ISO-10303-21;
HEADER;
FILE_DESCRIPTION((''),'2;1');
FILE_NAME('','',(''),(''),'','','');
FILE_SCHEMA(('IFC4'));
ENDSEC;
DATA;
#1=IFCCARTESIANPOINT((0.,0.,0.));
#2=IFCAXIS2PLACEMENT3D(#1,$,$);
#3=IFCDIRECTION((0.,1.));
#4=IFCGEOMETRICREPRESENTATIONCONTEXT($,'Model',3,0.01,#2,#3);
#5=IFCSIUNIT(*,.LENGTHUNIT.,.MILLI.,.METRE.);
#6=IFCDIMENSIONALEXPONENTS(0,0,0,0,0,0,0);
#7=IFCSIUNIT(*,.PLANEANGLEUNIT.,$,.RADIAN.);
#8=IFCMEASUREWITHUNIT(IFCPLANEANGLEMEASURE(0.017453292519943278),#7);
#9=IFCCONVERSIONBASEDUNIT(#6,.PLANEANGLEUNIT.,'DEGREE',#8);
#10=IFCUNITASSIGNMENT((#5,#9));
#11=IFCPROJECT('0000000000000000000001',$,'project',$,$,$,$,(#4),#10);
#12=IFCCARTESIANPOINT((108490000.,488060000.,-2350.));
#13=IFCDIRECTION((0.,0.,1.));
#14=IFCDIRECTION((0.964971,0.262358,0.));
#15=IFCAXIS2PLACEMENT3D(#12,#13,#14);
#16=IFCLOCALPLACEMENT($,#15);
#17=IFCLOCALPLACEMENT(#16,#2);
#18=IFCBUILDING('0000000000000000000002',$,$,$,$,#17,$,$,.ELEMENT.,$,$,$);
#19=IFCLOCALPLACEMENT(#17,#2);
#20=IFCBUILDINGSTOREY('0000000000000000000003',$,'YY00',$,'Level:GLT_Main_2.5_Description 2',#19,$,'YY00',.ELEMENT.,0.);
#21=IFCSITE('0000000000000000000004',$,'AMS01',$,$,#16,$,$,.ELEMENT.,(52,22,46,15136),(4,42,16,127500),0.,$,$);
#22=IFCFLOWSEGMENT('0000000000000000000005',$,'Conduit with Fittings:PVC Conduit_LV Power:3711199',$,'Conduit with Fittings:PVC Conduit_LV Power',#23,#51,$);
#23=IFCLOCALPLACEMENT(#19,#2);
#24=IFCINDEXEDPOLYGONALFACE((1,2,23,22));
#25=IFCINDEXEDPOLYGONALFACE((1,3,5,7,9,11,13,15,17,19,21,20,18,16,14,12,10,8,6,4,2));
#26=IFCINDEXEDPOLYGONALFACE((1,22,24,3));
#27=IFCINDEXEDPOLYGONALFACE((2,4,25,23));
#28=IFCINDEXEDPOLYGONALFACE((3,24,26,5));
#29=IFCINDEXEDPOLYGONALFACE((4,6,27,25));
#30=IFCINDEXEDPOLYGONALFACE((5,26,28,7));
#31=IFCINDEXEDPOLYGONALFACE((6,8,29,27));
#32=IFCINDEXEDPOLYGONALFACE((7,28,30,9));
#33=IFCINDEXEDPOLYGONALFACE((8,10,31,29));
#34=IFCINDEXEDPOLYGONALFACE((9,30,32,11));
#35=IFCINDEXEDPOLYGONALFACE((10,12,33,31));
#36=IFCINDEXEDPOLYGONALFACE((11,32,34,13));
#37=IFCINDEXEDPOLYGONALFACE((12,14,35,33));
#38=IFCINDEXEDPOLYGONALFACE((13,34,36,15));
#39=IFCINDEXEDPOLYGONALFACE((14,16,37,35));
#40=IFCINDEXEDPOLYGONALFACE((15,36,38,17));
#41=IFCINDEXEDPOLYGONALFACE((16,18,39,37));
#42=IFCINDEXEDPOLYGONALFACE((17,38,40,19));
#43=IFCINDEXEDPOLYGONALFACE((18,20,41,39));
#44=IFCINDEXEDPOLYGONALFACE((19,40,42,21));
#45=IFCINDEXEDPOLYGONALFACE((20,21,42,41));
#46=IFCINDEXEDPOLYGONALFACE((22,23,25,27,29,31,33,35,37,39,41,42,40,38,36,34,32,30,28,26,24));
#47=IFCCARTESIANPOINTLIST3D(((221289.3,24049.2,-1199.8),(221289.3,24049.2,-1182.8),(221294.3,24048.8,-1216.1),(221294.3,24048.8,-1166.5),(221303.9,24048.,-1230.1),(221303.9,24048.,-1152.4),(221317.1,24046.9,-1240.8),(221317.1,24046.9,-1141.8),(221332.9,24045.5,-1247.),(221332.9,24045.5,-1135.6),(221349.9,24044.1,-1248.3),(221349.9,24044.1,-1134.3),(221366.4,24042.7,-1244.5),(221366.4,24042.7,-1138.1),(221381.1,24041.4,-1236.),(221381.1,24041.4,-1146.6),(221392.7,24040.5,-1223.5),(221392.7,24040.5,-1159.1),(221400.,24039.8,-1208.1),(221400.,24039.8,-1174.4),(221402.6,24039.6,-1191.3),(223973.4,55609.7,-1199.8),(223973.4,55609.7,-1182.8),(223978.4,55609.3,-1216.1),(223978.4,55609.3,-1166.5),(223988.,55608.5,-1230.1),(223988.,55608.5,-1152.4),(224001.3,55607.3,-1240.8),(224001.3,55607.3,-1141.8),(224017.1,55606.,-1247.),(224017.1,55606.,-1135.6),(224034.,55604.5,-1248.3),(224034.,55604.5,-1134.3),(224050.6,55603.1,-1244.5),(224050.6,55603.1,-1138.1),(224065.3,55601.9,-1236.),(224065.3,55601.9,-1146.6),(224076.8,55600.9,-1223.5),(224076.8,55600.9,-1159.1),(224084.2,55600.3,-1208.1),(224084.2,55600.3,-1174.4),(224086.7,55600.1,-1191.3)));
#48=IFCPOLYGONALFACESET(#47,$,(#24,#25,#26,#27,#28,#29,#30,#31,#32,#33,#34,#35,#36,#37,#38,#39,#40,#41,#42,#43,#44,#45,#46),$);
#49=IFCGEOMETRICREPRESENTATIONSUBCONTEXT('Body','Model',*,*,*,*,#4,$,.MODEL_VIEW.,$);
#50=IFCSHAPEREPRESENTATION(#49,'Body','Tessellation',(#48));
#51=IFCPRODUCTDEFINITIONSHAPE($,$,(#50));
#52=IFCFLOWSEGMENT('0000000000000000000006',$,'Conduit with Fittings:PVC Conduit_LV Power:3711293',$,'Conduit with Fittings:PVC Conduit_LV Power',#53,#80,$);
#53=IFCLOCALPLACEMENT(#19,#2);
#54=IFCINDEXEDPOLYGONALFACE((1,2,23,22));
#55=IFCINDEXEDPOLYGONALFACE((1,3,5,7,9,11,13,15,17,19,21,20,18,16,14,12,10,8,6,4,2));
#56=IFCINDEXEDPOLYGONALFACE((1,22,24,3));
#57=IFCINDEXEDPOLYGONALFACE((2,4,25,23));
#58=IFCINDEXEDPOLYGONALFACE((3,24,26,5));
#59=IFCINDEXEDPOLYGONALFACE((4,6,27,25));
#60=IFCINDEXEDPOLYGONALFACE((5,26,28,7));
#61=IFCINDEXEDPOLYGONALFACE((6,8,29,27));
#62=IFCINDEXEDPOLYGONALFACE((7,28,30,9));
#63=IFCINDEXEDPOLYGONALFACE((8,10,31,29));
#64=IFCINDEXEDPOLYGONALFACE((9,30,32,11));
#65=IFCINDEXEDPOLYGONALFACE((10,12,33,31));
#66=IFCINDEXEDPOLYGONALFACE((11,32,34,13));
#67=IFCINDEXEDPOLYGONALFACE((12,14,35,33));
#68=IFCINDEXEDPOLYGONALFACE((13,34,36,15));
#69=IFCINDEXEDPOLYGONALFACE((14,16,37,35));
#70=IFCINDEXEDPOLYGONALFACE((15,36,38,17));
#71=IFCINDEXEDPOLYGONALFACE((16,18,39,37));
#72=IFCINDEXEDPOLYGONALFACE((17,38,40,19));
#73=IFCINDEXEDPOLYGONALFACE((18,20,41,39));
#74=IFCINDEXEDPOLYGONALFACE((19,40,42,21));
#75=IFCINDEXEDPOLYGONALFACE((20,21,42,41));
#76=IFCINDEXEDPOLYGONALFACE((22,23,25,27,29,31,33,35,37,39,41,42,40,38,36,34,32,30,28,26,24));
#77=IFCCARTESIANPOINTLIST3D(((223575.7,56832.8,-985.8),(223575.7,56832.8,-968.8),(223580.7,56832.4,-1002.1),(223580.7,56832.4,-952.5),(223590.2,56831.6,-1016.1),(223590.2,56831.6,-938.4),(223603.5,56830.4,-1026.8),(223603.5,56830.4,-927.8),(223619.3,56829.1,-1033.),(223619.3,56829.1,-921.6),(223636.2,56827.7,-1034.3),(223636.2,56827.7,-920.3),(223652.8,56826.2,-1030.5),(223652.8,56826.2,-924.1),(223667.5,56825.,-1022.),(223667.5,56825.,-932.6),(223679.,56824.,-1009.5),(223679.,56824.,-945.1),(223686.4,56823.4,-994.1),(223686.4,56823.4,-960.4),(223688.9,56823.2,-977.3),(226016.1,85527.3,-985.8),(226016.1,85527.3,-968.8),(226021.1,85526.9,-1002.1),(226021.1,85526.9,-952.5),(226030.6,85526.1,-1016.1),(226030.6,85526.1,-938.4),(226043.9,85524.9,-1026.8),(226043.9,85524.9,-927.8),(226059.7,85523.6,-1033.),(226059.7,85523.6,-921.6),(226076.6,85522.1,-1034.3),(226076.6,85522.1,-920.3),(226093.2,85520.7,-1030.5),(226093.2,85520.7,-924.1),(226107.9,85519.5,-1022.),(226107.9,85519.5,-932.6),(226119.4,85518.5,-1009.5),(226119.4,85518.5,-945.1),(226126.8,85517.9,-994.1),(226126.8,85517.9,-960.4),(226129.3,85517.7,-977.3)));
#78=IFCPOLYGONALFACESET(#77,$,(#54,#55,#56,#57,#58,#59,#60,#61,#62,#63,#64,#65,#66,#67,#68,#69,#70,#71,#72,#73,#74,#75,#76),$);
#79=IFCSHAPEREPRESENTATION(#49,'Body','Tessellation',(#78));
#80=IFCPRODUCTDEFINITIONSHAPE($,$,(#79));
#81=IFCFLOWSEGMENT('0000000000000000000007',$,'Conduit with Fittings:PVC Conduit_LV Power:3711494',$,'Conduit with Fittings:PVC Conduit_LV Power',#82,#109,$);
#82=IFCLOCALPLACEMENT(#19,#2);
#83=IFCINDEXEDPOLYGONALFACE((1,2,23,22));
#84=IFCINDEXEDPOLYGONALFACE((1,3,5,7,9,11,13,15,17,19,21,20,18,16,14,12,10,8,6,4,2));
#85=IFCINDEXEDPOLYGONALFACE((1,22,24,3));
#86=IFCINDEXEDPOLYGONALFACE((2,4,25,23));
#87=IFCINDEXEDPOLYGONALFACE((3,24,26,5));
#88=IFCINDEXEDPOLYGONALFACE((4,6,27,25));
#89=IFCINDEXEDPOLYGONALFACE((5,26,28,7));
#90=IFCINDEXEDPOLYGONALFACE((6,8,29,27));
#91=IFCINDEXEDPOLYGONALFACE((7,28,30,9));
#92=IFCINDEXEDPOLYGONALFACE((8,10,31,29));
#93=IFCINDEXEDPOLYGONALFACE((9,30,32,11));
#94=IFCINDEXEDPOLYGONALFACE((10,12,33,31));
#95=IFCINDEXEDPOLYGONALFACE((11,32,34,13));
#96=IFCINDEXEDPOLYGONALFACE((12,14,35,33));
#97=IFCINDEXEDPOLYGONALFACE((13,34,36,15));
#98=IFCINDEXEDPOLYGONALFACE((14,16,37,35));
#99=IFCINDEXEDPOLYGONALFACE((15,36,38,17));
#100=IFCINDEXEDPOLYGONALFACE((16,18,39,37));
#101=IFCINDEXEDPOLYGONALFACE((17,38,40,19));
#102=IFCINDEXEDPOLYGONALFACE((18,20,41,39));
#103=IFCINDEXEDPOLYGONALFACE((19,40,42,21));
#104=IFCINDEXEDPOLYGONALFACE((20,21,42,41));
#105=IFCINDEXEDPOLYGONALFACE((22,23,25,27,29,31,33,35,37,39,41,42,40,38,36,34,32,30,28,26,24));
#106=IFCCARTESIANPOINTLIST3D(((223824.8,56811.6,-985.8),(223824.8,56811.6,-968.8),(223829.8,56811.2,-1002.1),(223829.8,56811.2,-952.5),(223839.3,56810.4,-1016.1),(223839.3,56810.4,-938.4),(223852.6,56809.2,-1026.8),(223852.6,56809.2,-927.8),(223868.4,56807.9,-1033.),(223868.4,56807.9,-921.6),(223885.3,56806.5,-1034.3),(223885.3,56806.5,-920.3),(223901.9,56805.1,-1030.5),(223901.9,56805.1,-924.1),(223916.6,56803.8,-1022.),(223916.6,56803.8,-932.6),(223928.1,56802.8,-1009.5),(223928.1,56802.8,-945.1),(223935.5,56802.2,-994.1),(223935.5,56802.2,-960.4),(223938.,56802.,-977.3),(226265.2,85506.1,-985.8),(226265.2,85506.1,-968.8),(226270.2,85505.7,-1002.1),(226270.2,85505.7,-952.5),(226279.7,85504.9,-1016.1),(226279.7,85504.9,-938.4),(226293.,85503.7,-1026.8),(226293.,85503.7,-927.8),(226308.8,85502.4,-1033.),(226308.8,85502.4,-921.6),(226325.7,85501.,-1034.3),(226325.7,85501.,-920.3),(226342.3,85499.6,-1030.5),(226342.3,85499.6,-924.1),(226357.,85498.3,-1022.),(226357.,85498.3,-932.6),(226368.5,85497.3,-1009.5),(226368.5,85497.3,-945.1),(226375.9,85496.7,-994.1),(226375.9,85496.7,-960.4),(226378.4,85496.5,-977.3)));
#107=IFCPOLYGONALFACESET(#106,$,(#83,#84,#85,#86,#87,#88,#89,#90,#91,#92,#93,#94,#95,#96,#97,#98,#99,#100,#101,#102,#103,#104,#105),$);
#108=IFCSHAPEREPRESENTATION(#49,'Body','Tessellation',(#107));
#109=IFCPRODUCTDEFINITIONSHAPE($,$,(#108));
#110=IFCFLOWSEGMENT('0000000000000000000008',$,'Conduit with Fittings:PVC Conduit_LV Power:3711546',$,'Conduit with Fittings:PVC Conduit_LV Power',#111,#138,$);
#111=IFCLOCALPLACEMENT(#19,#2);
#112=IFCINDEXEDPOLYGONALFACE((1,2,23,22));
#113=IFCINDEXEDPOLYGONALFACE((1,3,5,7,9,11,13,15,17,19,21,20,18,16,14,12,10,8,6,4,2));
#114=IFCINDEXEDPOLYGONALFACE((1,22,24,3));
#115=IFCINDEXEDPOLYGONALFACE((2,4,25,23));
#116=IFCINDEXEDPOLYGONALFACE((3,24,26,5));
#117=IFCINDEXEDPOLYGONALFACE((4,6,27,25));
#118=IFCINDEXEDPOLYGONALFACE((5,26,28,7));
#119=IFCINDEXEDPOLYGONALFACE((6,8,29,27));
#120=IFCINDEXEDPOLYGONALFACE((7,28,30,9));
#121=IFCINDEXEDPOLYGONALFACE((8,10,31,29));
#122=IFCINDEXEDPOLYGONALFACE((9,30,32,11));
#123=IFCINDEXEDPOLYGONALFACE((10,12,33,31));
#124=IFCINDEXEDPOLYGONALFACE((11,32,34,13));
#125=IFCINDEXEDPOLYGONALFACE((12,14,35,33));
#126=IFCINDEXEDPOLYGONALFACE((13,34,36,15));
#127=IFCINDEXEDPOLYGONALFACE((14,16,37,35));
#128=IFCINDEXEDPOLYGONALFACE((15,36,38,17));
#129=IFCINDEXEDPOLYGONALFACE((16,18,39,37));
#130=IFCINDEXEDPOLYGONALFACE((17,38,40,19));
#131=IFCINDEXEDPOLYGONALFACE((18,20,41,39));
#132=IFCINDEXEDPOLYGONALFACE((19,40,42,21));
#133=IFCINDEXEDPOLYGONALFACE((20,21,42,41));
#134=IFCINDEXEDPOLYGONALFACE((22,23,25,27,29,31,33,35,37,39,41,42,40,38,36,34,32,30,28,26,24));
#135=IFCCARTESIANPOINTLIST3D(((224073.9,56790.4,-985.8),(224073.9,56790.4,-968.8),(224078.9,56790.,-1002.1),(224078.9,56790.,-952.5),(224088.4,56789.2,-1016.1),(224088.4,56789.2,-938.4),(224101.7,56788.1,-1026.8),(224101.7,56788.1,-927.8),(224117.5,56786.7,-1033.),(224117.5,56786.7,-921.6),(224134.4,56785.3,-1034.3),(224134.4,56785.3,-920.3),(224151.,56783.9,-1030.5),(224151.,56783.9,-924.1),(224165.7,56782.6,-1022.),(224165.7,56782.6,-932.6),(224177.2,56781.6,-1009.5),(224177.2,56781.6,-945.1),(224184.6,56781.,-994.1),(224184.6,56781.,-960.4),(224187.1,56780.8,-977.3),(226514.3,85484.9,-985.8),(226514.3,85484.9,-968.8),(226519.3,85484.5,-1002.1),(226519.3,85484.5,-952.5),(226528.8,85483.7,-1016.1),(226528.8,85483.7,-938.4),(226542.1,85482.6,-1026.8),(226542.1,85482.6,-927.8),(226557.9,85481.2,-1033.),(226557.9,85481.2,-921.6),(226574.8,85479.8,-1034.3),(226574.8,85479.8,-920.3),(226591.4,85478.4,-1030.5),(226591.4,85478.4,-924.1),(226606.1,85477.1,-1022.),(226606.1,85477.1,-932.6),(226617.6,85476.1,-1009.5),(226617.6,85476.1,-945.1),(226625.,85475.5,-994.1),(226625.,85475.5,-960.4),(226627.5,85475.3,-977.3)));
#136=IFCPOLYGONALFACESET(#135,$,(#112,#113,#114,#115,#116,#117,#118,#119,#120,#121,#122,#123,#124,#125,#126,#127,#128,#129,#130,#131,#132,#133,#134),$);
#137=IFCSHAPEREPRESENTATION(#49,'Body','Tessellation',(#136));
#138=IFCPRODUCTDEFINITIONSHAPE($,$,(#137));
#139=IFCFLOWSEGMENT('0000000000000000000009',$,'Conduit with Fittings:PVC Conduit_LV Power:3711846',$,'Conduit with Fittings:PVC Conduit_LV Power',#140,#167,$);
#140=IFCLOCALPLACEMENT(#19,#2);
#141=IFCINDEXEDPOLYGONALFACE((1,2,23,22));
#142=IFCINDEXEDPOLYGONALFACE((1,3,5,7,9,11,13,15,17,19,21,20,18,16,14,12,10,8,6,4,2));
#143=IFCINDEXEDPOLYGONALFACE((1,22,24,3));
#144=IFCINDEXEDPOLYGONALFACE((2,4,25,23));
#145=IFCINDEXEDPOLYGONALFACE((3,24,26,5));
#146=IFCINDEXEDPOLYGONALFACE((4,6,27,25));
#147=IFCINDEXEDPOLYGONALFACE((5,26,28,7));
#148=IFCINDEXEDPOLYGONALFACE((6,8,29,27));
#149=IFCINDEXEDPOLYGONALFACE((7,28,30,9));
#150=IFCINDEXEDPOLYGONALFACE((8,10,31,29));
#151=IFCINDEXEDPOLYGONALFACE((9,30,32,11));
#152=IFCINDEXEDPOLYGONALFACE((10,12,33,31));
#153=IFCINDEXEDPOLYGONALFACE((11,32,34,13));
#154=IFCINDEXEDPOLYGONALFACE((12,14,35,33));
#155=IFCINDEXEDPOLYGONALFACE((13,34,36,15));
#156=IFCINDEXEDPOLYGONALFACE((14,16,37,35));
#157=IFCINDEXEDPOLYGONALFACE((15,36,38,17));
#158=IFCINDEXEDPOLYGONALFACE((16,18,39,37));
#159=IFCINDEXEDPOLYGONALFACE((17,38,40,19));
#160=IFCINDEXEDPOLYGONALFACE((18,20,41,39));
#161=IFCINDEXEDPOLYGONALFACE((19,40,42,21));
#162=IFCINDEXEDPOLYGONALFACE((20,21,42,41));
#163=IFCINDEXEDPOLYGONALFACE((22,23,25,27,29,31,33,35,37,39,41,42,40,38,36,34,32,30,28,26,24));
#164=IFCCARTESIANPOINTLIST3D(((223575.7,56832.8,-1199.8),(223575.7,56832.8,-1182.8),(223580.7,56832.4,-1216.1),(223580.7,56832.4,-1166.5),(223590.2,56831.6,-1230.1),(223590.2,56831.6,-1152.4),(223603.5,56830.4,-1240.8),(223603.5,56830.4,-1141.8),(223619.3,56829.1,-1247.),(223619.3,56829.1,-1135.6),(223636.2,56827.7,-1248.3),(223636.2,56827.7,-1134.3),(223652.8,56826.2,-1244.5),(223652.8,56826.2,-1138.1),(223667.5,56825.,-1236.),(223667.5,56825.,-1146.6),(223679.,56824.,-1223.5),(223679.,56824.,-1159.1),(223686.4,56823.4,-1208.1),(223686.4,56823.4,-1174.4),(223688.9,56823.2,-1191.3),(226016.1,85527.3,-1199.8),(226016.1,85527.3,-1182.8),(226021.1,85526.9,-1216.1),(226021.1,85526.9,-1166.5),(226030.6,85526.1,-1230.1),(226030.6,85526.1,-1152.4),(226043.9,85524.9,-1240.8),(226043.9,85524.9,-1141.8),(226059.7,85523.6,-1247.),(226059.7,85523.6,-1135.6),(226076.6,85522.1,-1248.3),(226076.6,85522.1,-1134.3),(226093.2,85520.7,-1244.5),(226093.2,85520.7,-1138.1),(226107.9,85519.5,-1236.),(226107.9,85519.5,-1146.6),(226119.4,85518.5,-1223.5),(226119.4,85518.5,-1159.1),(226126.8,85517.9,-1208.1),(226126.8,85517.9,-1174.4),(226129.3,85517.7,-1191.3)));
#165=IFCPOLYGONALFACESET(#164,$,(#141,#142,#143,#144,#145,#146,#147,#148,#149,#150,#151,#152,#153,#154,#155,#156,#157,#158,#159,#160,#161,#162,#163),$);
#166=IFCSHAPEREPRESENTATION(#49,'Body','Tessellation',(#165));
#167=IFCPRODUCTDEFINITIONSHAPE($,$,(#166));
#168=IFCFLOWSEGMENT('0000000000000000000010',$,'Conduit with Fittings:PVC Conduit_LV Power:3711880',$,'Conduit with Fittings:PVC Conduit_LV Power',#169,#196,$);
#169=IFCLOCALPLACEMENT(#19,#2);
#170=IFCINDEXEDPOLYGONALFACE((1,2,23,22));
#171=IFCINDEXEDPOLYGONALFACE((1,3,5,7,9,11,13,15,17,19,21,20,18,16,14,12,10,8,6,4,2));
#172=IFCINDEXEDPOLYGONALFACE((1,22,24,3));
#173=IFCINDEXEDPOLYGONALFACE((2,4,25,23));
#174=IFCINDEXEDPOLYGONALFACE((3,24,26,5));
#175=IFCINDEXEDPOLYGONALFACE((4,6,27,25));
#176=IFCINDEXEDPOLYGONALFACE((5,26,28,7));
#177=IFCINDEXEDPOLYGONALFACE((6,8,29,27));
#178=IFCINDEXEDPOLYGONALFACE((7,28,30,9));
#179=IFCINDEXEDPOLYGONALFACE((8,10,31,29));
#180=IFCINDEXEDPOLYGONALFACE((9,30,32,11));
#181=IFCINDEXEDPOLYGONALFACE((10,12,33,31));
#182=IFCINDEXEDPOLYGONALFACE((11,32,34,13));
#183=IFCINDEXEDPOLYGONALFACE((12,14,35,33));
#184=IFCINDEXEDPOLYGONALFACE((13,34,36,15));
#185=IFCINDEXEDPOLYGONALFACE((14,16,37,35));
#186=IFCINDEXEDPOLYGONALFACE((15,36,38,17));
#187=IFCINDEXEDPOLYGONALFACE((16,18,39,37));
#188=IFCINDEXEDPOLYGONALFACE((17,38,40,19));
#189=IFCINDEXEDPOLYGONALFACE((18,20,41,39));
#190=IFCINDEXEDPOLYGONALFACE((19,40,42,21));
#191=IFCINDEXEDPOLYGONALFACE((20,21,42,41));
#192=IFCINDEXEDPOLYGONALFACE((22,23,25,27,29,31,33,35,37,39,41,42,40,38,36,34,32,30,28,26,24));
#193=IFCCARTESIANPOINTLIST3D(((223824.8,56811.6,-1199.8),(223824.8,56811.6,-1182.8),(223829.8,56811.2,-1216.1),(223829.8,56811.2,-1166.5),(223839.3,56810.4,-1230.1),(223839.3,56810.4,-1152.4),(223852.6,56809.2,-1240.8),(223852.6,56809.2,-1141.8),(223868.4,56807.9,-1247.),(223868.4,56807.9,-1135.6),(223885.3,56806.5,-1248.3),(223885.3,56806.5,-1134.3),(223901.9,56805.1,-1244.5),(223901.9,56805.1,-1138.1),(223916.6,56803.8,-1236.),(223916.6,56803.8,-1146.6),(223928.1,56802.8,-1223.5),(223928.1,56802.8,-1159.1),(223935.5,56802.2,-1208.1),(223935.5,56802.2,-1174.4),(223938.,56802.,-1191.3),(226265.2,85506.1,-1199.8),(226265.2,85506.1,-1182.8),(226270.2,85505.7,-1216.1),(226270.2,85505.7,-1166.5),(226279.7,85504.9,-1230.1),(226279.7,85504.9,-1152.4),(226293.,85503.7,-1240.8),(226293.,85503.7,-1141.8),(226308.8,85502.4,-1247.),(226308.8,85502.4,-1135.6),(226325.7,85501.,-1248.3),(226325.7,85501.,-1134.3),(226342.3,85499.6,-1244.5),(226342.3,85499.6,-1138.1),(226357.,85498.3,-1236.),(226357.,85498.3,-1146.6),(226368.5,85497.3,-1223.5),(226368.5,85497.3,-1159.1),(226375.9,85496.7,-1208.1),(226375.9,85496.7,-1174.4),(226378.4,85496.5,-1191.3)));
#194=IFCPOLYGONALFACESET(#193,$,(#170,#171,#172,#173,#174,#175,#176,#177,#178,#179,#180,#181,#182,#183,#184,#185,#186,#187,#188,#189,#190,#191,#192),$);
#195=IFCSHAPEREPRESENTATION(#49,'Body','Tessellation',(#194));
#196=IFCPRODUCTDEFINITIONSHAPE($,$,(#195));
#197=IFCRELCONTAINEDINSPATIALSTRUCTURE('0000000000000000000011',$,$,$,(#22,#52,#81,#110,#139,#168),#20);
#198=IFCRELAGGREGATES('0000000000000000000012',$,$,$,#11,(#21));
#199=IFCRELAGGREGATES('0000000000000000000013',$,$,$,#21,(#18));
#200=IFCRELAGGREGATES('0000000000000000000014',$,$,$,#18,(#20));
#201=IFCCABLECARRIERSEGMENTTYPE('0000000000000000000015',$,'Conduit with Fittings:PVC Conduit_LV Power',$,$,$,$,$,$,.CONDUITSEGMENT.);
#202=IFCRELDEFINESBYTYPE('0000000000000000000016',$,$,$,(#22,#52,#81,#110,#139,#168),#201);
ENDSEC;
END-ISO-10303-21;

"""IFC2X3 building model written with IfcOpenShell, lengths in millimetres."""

from ifc_helpers import new_model, entity, si_unit, converted_unit, direction, frame, origin, origin_2d_with_axis, place, context, subcontext, project, spatial, circle, extrude, type_object, element, save


model = new_model("IFC2X3")

# Units and contexts
model_context = context("Model", 3, precision=0.01, world=origin(), true_north=direction((0.0, 1.0)))
body_context = subcontext(model_context, "Body", "Model", "MODEL_VIEW")
ifc_project = project(units=[si_unit("LENGTHUNIT", "METRE", prefix="MILLI"), converted_unit("PLANEANGLEUNIT", "DEGREE", entity("IfcPlaneAngleMeasure", 0.017453292519943278), si_unit("PLANEANGLEUNIT", "RADIAN"), dimensions=[0, 0, 0, 0, 0, 0, 0])], contexts=[model_context])

# Site, building, storey
site_placement = place(None, frame((108490000.0, 488060000.0, -2350.0), z_axis=(0.0, 0.0, 1.0), x_axis=(0.964971, 0.262358, 0.0)))
site = spatial("IfcSite", under=ifc_project, at=site_placement, Name="AMS01", CompositionType="ELEMENT", RefLatitude=(52, 22, 46, 15136), RefLongitude=(4, 42, 16, 127500), RefElevation=0.0)
building_placement = place(site_placement, origin())
building = spatial("IfcBuilding", under=site, at=building_placement, CompositionType="ELEMENT")
storey_placement = place(building_placement, origin())
storey = spatial("IfcBuildingStorey", under=building, at=storey_placement, Name="YY00", ObjectType="Level:GLT_Main_2.5_Description 2", LongName="YY00", CompositionType="ELEMENT", Elevation=0.0)

# Flow segments
cable_carrier_segment_type = type_object("IfcCableCarrierSegmentType", Name="Conduit with Fittings:PVC Conduit_LV Power", PredefinedType="CONDUITSEGMENT")
flow_segment_1_placement = place(storey_placement, origin())
element("IfcFlowSegment", 1, at=flow_segment_1_placement, inside=storey, type_object=cable_carrier_segment_type, Name="Conduit with Fittings:PVC Conduit_LV Power:3711199", ObjectType="Conduit with Fittings:PVC Conduit_LV Power", context=body_context, shape_type="SweptSolid", body=[
    extrude(circle(Radius=57.2, at=origin_2d_with_axis()), frame((221345.6, 24044.5, -1191.3), z_axis=(0.084742, 0.996403, 0.0), x_axis=(0.996403, -0.084742, 0.0)), (0.0, 0.0, 1.0), 31674.4),
])
flow_segment_2_placement = place(storey_placement, origin())
element("IfcFlowSegment", 2, at=flow_segment_2_placement, inside=storey, type_object=cable_carrier_segment_type, Name="Conduit with Fittings:PVC Conduit_LV Power:3711293", ObjectType="Conduit with Fittings:PVC Conduit_LV Power", context=body_context, shape_type="SweptSolid", body=[
    extrude(circle(Radius=57.2, at=origin_2d_with_axis()), frame((223632.0, 56828.0, -977.3), z_axis=(0.084742, 0.996403, 0.0), x_axis=(0.996403, -0.084742, 0.0)), (0.0, 0.0, 1.0), 28798.1),
])
flow_segment_3_placement = place(storey_placement, origin())
element("IfcFlowSegment", 3, at=flow_segment_3_placement, inside=storey, type_object=cable_carrier_segment_type, Name="Conduit with Fittings:PVC Conduit_LV Power:3711494", ObjectType="Conduit with Fittings:PVC Conduit_LV Power", context=body_context, shape_type="SweptSolid", body=[
    extrude(circle(Radius=57.2, at=origin_2d_with_axis()), frame((223881.1, 56806.8, -977.3), z_axis=(0.084742, 0.996403, 0.0), x_axis=(0.996403, -0.084742, 0.0)), (0.0, 0.0, 1.0), 28798.1),
])
flow_segment_4_placement = place(storey_placement, origin())
element("IfcFlowSegment", 4, at=flow_segment_4_placement, inside=storey, type_object=cable_carrier_segment_type, Name="Conduit with Fittings:PVC Conduit_LV Power:3711546", ObjectType="Conduit with Fittings:PVC Conduit_LV Power", context=body_context, shape_type="SweptSolid", body=[
    extrude(circle(Radius=57.2, at=origin_2d_with_axis()), frame((224130.2, 56785.6, -977.3), z_axis=(0.084742, 0.996403, 0.0), x_axis=(0.996403, -0.084742, 0.0)), (0.0, 0.0, 1.0), 28798.1),
])
flow_segment_5_placement = place(storey_placement, origin())
element("IfcFlowSegment", 5, at=flow_segment_5_placement, inside=storey, type_object=cable_carrier_segment_type, Name="Conduit with Fittings:PVC Conduit_LV Power:3711846", ObjectType="Conduit with Fittings:PVC Conduit_LV Power", context=body_context, shape_type="SweptSolid", body=[
    extrude(circle(Radius=57.2, at=origin_2d_with_axis()), frame((223632.0, 56828.0, -1191.3), z_axis=(0.084742, 0.996403, 0.0), x_axis=(0.996403, -0.084742, 0.0)), (0.0, 0.0, 1.0), 28798.1),
])
flow_segment_6_placement = place(storey_placement, origin())
element("IfcFlowSegment", 6, at=flow_segment_6_placement, inside=storey, type_object=cable_carrier_segment_type, Name="Conduit with Fittings:PVC Conduit_LV Power:3711880", ObjectType="Conduit with Fittings:PVC Conduit_LV Power", context=body_context, shape_type="SweptSolid", body=[
    extrude(circle(Radius=57.2, at=origin_2d_with_axis()), frame((223881.1, 56806.8, -1191.3), z_axis=(0.084742, 0.996403, 0.0), x_axis=(0.996403, -0.084742, 0.0)), (0.0, 0.0, 1.0), 28798.1),
])

save(model, "model.ifc")
